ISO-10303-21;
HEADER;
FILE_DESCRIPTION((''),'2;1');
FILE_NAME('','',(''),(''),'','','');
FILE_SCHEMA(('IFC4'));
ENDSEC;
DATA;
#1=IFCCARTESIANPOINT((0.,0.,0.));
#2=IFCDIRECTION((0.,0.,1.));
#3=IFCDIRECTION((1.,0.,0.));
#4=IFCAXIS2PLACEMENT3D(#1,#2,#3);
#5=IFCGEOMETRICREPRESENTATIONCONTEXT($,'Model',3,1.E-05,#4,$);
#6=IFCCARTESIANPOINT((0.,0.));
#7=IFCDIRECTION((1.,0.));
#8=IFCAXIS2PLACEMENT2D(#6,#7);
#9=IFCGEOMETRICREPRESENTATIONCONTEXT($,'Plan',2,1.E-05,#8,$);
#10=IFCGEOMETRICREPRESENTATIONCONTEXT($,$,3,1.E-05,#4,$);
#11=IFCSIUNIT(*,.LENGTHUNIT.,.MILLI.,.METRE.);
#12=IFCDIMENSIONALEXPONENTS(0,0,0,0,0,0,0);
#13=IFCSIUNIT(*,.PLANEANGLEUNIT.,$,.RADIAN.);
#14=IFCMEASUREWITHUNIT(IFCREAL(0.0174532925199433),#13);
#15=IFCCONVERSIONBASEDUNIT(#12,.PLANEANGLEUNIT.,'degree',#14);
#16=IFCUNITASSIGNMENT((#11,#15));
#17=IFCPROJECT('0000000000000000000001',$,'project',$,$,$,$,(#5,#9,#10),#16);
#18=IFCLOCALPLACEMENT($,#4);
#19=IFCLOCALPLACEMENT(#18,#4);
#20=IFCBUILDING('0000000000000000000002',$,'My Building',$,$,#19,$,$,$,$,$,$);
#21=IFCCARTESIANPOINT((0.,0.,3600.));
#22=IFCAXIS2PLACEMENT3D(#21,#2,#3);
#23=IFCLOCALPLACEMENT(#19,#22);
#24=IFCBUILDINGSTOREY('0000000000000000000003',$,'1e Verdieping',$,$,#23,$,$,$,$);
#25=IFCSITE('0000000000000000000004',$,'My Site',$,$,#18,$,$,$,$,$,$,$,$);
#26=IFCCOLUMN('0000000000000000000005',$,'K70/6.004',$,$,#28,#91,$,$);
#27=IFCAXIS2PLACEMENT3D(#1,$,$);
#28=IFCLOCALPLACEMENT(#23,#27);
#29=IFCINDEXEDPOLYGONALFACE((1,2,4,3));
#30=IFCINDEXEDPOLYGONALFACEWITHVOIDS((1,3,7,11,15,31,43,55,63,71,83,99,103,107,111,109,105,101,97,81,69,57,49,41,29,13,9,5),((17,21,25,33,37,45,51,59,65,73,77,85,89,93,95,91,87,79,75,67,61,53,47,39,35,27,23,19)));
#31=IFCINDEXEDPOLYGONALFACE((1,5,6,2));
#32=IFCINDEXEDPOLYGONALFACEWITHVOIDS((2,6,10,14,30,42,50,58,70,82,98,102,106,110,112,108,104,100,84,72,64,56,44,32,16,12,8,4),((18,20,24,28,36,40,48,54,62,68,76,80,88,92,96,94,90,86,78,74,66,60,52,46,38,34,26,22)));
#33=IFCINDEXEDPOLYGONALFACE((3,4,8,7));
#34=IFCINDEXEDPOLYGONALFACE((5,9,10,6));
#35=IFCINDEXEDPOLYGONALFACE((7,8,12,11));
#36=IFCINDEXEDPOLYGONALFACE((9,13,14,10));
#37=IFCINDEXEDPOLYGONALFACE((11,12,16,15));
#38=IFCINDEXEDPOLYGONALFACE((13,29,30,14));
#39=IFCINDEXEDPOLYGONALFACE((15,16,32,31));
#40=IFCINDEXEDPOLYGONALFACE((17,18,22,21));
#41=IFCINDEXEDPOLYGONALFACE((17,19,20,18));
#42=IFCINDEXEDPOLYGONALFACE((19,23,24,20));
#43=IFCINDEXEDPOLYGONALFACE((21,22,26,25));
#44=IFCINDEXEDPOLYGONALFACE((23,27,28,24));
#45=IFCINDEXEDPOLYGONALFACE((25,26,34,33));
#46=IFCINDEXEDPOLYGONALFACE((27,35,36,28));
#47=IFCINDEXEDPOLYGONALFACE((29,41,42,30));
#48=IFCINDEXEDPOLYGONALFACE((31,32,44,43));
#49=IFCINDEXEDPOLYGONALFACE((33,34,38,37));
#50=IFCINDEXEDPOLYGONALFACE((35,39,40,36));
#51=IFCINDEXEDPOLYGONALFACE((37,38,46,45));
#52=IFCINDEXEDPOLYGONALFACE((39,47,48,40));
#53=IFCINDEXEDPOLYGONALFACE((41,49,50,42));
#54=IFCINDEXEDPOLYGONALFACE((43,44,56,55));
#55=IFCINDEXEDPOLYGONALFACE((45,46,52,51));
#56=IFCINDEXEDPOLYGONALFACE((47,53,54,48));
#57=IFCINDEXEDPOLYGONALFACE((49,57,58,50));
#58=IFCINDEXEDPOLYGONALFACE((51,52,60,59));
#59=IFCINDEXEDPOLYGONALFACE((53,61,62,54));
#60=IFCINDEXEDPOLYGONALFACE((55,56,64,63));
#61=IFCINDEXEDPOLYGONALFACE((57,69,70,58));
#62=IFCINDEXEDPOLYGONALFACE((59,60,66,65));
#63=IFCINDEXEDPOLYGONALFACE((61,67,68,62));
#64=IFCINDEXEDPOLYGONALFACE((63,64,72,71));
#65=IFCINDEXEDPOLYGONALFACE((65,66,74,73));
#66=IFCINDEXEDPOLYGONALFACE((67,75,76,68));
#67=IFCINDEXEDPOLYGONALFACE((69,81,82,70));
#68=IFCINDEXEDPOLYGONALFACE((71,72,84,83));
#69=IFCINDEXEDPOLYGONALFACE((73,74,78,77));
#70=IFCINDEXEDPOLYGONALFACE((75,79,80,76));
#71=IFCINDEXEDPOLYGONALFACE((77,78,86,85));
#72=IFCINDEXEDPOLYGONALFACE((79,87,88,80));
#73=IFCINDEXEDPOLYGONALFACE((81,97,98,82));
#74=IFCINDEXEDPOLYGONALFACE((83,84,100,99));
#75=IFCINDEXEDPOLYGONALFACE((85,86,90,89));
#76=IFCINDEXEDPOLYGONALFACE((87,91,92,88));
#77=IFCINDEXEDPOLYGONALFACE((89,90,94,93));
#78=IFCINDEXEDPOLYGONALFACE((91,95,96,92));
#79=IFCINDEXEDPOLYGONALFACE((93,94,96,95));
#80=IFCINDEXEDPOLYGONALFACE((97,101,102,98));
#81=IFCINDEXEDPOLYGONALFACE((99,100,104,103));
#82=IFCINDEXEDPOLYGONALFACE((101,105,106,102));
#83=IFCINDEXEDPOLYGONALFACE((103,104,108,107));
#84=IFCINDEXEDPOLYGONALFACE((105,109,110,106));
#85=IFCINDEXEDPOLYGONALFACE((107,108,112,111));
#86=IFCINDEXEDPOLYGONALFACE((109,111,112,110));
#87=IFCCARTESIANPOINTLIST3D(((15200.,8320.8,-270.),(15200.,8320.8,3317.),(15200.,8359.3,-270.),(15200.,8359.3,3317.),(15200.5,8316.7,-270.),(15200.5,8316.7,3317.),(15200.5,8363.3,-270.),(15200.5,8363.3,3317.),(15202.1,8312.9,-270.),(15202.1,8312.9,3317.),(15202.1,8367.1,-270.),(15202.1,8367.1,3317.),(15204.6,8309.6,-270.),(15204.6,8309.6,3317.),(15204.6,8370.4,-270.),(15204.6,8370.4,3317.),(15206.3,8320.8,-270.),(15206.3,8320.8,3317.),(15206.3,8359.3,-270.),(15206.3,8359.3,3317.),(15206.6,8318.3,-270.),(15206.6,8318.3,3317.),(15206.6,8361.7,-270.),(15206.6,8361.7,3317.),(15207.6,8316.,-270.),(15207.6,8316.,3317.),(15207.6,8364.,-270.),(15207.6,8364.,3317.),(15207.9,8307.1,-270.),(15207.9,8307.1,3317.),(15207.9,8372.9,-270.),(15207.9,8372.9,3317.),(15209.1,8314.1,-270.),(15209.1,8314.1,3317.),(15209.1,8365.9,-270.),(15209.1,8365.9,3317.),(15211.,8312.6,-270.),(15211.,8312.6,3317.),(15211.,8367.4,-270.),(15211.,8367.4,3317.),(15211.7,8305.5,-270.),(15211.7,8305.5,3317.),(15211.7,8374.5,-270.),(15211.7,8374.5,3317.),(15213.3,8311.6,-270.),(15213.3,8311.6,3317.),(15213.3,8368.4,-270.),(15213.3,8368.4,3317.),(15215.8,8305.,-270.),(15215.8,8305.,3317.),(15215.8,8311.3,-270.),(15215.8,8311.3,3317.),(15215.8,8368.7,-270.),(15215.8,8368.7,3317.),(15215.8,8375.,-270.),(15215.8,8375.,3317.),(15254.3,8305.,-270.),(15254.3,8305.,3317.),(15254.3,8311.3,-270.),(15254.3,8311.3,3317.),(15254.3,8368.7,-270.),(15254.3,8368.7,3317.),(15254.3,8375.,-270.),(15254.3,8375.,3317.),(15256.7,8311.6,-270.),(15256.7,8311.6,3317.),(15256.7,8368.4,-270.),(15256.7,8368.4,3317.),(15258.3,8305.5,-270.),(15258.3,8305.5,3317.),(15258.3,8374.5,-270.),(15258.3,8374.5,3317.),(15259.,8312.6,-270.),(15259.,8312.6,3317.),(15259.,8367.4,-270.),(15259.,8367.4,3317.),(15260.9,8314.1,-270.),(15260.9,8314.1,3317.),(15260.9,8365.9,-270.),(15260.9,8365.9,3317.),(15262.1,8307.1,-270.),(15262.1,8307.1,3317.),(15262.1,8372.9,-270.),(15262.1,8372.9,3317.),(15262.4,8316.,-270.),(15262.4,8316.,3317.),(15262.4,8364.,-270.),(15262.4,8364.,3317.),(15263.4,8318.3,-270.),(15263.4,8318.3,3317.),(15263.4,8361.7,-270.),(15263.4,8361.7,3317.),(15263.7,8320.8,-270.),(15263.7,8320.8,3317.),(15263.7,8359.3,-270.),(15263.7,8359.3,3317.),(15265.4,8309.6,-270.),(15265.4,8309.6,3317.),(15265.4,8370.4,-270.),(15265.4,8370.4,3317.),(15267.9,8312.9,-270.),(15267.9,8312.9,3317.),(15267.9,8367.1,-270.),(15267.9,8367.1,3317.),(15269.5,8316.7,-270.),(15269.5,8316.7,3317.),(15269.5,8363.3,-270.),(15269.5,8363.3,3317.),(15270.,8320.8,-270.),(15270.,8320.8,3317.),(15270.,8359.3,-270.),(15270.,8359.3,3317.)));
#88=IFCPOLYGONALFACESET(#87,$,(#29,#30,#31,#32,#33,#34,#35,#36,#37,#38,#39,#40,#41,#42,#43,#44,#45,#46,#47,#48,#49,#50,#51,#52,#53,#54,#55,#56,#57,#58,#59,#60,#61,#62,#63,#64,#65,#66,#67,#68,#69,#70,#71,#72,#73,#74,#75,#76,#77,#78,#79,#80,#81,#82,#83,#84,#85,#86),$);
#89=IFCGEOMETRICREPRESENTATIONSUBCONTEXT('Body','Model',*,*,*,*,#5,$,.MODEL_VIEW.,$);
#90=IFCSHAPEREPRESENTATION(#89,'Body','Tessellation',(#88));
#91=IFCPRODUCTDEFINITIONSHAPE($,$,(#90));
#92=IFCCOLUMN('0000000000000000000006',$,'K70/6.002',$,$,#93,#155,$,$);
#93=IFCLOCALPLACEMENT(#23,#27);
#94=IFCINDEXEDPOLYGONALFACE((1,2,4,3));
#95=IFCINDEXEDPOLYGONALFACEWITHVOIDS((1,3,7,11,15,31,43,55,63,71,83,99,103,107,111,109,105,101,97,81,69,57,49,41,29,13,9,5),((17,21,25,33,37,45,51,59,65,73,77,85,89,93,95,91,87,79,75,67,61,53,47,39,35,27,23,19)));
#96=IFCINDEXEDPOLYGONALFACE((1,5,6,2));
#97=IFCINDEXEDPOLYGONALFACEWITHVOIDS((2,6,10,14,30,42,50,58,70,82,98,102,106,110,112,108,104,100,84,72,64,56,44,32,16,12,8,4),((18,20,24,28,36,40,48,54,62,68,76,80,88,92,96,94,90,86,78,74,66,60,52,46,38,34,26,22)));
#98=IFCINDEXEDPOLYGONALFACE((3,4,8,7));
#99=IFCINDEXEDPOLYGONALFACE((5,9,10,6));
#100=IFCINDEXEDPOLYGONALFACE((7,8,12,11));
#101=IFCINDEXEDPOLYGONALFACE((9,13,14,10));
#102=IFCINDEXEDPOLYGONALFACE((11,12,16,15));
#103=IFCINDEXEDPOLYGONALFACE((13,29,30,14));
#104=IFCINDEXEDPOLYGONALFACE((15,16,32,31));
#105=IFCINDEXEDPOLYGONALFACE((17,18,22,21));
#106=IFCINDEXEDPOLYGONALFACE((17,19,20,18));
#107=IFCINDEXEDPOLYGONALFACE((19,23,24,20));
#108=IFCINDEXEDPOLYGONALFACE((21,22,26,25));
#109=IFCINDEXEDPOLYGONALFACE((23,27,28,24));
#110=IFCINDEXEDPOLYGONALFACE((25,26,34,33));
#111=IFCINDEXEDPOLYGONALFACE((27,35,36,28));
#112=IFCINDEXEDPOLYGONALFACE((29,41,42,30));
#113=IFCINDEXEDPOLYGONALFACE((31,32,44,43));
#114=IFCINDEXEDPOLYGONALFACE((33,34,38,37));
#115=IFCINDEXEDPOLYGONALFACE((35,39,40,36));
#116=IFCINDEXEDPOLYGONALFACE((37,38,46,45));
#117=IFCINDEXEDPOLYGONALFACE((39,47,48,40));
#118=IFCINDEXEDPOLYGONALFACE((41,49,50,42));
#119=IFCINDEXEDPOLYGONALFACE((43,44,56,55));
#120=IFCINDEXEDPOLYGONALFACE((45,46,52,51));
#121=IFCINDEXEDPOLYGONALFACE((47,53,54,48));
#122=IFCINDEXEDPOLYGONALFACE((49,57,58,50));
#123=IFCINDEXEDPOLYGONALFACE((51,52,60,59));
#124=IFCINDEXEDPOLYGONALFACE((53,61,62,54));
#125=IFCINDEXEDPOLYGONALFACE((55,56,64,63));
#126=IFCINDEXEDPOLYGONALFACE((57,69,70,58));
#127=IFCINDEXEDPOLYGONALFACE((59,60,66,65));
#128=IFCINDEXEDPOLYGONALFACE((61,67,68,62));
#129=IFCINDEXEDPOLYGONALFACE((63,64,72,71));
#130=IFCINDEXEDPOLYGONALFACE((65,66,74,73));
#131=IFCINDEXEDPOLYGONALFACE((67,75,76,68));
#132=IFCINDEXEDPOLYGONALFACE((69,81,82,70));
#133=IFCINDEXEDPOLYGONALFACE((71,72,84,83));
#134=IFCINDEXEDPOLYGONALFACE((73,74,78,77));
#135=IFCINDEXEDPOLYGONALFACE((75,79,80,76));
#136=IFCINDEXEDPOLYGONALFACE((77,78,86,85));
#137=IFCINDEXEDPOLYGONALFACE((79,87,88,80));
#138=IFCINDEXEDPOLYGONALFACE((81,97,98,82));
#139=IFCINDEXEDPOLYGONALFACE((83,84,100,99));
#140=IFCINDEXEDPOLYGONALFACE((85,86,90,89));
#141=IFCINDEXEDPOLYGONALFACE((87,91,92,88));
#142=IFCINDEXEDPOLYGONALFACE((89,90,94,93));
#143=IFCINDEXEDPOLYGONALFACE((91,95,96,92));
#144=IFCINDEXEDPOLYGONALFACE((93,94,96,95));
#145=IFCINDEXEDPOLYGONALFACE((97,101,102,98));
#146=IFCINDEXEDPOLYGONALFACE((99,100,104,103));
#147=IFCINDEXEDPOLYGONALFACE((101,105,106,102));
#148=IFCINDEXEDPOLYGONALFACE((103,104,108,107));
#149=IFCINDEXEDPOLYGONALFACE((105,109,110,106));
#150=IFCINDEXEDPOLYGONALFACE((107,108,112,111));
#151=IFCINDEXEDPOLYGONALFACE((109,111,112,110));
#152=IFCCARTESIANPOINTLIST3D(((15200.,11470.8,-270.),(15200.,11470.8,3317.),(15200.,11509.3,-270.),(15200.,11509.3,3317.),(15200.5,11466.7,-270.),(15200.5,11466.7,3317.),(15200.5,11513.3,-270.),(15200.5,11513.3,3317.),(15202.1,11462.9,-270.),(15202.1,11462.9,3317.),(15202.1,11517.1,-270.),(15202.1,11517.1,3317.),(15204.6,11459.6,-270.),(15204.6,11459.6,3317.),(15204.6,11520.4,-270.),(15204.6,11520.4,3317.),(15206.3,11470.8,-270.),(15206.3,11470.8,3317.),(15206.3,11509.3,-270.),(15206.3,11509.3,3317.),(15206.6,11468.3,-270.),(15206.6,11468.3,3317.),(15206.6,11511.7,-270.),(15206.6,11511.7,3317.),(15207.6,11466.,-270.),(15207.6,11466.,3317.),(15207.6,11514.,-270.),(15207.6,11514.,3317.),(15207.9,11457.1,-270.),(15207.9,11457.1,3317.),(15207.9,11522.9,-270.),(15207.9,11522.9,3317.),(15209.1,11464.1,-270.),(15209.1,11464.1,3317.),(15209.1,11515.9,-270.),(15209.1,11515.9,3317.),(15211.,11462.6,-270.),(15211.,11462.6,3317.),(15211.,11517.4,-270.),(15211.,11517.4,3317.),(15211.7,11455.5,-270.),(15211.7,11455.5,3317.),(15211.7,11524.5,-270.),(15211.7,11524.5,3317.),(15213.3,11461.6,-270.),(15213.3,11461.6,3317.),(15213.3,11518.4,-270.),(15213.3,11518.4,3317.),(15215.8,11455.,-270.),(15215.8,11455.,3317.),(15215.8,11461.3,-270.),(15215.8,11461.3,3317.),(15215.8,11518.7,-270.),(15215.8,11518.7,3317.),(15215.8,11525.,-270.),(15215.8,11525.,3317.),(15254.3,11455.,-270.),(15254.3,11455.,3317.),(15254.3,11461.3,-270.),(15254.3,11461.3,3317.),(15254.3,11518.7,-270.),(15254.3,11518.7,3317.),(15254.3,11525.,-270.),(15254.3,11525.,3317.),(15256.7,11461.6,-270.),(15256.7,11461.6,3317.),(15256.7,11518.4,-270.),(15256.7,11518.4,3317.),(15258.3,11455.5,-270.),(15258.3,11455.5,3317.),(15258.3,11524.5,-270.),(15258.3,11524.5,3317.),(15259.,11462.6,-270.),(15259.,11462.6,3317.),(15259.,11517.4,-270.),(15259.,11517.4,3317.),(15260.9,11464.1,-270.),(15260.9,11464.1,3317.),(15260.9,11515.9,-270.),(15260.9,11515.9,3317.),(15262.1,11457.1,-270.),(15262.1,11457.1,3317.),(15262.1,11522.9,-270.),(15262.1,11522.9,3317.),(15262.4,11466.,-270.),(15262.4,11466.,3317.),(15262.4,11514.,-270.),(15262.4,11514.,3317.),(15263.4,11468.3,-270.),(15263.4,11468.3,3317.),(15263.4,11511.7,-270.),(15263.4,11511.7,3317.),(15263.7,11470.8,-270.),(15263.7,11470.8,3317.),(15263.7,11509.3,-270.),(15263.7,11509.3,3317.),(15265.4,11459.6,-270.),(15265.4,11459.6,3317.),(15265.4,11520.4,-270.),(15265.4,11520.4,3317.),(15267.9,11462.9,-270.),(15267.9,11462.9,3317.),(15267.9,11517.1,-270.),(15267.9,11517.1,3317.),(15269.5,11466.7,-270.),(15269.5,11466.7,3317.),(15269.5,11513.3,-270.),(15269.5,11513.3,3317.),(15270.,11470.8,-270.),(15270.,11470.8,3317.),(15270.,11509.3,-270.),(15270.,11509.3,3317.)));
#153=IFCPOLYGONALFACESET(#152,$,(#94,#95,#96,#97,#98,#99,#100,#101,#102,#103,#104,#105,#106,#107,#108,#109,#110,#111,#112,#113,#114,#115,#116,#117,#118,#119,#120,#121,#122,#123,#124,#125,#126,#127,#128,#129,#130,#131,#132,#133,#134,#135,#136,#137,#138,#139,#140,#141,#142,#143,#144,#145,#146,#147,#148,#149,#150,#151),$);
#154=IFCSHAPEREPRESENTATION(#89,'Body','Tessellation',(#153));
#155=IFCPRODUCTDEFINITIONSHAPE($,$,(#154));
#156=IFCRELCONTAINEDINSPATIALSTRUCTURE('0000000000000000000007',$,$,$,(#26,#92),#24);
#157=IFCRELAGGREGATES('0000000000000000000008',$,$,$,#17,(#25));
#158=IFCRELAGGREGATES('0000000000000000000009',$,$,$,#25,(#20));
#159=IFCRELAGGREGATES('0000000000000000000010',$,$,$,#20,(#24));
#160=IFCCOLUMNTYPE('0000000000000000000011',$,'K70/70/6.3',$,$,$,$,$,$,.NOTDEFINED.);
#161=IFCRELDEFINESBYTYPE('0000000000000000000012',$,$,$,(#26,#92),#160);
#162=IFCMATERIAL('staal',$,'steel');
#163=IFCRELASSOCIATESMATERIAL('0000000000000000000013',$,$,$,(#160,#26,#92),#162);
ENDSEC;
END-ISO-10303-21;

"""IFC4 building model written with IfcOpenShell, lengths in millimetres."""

from ifc_helpers import new_model, entity, si_unit, converted_unit, frame, origin_with_axes, origin_2d_with_axis, place, context, subcontext, project, spatial, hollow_rectangle, extrude, material, material_profile, profile_set, profile_usage, type_object, element, save


model = new_model("IFC4")

# Units and contexts
model_context = context("Model", 3, precision=1e-05, world=origin_with_axes())
plan_context = context("Plan", 2, precision=1e-05, world=origin_2d_with_axis())
context_of_model = context(None, 3, precision=1e-05, world=origin_with_axes())
body_context = subcontext(model_context, "Body", "Model", "MODEL_VIEW")
ifc_project = project(units=[si_unit("LENGTHUNIT", "METRE", prefix="MILLI"), converted_unit("PLANEANGLEUNIT", "degree", entity("IfcReal", 0.0174532925199433), si_unit("PLANEANGLEUNIT", "RADIAN"), dimensions=[0, 0, 0, 0, 0, 0, 0])], contexts=[model_context, plan_context, context_of_model])

# Site, building, storey
site_placement = place(None, origin_with_axes())
site = spatial("IfcSite", under=ifc_project, at=site_placement, Name="My Site")
building_placement = place(site_placement, origin_with_axes())
building = spatial("IfcBuilding", under=site, at=building_placement, Name="My Building")
storey_placement = place(building_placement, frame((0.0, 0.0, 3600.0), z_axis=(0.0, 0.0, 1.0), x_axis=(1.0, 0.0, 0.0)))
storey = spatial("IfcBuildingStorey", under=building, at=storey_placement, Name="1e Verdieping")

# Columns
ifc_material = material(Name="staal", Category="steel")
ifc_material_profile_1 = material_profile(ifc_material, hollow_rectangle(XDim=70.0, YDim=70.0, WallThickness=6.3, InnerFilletRadius=9.4, OuterFilletRadius=15.8))
ifc_profile_set_1 = profile_set([ifc_material_profile_1], Name="K70/70/6.3")
ifc_profile_usage_1 = profile_usage(ifc_profile_set_1)
column_type_1 = type_object("IfcColumnType", Name="K70/70/6.3", PredefinedType="NOTDEFINED", material=ifc_profile_set_1)
column_1_placement = place(storey_placement, frame((15235.0, 8340.0, -270.0), z_axis=(0.0, 0.0, 1.0), x_axis=(1.0, 0.0, 0.0)))
element("IfcColumn", 1, at=column_1_placement, inside=storey, type_object=column_type_1, material=ifc_profile_usage_1, Name="K70/6.004", context=body_context, shape_type="SweptSolid", body=[
    extrude(hollow_rectangle(XDim=70.0, YDim=70.0, WallThickness=6.3, InnerFilletRadius=9.4, OuterFilletRadius=15.8), origin_with_axes(), (0.0, 0.0, 1.0), 3587.0),
])
ifc_profile_usage_2 = profile_usage(ifc_profile_set_1)
column_2_placement = place(storey_placement, frame((15235.0, 11490.0, -270.0), z_axis=(0.0, 0.0, 1.0), x_axis=(1.0, 0.0, 0.0)))
element("IfcColumn", 2, at=column_2_placement, inside=storey, type_object=column_type_1, material=ifc_profile_usage_2, Name="K70/6.002", context=body_context, shape_type="SweptSolid", body=[
    extrude(hollow_rectangle(XDim=70.0, YDim=70.0, WallThickness=6.3, InnerFilletRadius=9.4, OuterFilletRadius=15.8), origin_with_axes(), (0.0, 0.0, 1.0), 3587.0),
])

save(model, "model.ifc")
